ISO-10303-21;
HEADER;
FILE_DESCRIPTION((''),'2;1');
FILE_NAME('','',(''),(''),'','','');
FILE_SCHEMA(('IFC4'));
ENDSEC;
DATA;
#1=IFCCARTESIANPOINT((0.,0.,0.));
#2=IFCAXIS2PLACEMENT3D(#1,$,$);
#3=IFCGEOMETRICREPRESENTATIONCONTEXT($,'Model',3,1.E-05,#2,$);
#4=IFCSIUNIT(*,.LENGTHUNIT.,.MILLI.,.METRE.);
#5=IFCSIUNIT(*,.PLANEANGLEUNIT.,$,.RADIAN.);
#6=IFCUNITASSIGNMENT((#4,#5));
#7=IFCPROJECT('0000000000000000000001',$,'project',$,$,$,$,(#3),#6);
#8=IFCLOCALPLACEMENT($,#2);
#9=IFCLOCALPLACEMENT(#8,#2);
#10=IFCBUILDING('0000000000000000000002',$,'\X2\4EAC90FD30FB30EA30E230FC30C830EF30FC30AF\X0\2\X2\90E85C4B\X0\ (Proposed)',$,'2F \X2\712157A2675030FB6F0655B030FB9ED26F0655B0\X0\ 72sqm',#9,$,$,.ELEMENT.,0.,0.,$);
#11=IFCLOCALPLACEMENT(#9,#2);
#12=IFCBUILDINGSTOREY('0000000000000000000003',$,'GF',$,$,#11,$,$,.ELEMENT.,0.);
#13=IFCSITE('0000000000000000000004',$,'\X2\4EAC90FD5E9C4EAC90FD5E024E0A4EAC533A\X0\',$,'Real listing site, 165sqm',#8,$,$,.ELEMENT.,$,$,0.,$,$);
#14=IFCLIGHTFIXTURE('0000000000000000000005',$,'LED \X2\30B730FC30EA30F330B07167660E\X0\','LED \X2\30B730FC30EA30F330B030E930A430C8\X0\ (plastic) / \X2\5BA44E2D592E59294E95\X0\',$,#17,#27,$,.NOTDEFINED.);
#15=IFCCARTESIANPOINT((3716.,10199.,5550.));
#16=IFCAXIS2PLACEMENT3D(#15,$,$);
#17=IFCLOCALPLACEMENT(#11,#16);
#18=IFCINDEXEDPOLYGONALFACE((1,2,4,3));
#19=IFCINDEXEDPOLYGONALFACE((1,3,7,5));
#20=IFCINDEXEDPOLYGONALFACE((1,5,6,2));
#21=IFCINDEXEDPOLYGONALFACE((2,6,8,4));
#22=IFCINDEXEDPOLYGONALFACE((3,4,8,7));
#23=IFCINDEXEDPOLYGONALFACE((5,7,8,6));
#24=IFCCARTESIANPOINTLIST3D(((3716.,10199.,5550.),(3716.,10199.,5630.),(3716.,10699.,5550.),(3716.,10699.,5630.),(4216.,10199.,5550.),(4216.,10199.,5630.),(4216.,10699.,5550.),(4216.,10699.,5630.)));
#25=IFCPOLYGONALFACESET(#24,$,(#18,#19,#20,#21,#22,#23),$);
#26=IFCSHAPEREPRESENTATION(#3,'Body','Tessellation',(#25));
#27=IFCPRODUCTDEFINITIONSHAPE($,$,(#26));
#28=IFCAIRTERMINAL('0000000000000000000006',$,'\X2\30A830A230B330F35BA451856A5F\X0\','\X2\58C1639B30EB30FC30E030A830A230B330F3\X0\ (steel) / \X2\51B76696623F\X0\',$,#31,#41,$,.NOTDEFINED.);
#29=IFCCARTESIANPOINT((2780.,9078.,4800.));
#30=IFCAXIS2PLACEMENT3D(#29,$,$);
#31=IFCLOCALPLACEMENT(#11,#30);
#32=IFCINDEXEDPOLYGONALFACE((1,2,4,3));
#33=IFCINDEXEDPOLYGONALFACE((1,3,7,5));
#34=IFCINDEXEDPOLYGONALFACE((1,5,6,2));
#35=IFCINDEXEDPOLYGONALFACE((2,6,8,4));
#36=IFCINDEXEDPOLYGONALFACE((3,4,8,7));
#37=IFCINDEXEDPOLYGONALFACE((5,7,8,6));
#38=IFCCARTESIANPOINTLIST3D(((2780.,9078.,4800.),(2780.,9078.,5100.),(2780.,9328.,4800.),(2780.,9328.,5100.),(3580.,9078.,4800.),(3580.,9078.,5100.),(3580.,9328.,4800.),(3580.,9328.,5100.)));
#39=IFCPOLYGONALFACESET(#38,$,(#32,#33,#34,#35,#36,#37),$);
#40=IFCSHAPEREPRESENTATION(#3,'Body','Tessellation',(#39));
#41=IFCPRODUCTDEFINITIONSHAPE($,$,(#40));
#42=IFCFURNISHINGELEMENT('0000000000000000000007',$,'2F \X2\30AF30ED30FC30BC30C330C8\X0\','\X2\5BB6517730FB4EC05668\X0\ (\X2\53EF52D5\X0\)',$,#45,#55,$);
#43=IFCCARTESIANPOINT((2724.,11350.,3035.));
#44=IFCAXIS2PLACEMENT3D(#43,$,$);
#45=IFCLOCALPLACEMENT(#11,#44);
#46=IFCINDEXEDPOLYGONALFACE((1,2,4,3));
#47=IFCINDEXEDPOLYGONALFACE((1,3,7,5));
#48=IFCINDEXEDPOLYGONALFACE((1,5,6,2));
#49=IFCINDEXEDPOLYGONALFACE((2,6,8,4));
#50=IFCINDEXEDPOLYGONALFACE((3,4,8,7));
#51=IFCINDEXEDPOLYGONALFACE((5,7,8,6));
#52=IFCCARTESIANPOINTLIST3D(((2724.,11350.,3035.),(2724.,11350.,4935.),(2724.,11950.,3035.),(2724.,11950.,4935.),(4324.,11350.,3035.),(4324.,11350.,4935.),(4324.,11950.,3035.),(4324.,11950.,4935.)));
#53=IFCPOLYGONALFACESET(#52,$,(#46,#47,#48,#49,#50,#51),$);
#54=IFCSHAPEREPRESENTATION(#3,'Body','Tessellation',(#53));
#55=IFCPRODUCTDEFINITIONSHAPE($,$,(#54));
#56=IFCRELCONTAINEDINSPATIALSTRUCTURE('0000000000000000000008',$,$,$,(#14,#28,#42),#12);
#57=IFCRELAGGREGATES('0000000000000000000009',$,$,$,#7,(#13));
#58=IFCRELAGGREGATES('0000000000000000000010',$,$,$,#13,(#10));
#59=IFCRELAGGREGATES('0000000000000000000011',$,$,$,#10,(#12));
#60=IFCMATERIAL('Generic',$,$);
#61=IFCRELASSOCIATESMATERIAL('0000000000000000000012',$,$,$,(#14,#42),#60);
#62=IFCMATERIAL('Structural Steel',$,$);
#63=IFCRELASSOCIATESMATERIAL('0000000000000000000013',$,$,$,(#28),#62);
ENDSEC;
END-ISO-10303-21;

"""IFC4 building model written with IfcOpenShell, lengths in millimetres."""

from ifc_helpers import new_model, si_unit, frame, frame_2d, origin, place, context, project, spatial, rectangle, extrude, material, element, save


model = new_model("IFC4")

# Units and contexts
model_context = context("Model", 3, precision=1e-05, world=origin())
ifc_project = project(units=[si_unit("LENGTHUNIT", "METRE", prefix="MILLI"), si_unit("PLANEANGLEUNIT", "RADIAN")], contexts=[model_context])

# Site, building, storey
site_placement = place(None, origin())
site = spatial("IfcSite", under=ifc_project, at=site_placement, Name="京都府京都市上京区", ObjectType="Real listing site, 165sqm", CompositionType="ELEMENT", RefElevation=0.0)
building_placement = place(site_placement, origin())
building = spatial("IfcBuilding", under=site, at=building_placement, Name="京都・リモートワーク2部屋 (Proposed)", ObjectType="2F 無垢材・漆喰・黒漆喰 72sqm", CompositionType="ELEMENT", ElevationOfRefHeight=0.0, ElevationOfTerrain=0.0)
storey_placement = place(building_placement, origin())
storey = spatial("IfcBuildingStorey", under=building, at=storey_placement, Name="GF", CompositionType="ELEMENT", Elevation=0.0)

# Shared definitions
ifc_material_1 = material(Name="Generic")

# Shared definitions
ifc_material_2 = material(Name="Structural Steel")

# Light fixture
light_fixture_1_placement = place(storey_placement, frame((3716.0, 10199.0, 5550.0)))
element("IfcLightFixture", 1, at=light_fixture_1_placement, inside=storey, material=ifc_material_1, Name="LED シーリング照明", Description="LED シーリングライト (plastic) / 室中央天井", PredefinedType="NOTDEFINED", context=model_context, shape_type="SweptSolid", body=[
    extrude(rectangle(XDim=500.0, YDim=500.0, at=frame_2d((250.0, 250.0))), frame((3716.0, 10199.0, 5550.0)), (0.0, 0.0, 1.0), 80.0),
])

# Air terminal
air_terminal_placement = place(storey_placement, frame((2780.0, 9078.0, 4800.0)))
element("IfcAirTerminal", 2, at=air_terminal_placement, inside=storey, material=ifc_material_2, Name="エアコン室内機", Description="壁掛ルームエアコン (steel) / 冷暖房", PredefinedType="NOTDEFINED", context=model_context, shape_type="SweptSolid", body=[
    extrude(rectangle(XDim=800.0, YDim=250.0, at=frame_2d((400.0, 125.0))), frame((2780.0, 9078.0, 4800.0)), (0.0, 0.0, 1.0), 300.0),
])

# Furnishing element
furnishing_placement = place(storey_placement, frame((2724.0, 11350.0, 3035.0)))
element("IfcFurnishingElement", 3, at=furnishing_placement, inside=storey, material=ifc_material_1, Name="2F クローゼット", Description="家具・什器 (可動)", context=model_context, shape_type="SweptSolid", body=[
    extrude(rectangle(XDim=1600.0, YDim=600.0, at=frame_2d((800.0, 300.0))), frame((2724.0, 11350.0, 3035.0)), (0.0, 0.0, 1.0), 1900.0),
])

save(model, "model.ifc")
